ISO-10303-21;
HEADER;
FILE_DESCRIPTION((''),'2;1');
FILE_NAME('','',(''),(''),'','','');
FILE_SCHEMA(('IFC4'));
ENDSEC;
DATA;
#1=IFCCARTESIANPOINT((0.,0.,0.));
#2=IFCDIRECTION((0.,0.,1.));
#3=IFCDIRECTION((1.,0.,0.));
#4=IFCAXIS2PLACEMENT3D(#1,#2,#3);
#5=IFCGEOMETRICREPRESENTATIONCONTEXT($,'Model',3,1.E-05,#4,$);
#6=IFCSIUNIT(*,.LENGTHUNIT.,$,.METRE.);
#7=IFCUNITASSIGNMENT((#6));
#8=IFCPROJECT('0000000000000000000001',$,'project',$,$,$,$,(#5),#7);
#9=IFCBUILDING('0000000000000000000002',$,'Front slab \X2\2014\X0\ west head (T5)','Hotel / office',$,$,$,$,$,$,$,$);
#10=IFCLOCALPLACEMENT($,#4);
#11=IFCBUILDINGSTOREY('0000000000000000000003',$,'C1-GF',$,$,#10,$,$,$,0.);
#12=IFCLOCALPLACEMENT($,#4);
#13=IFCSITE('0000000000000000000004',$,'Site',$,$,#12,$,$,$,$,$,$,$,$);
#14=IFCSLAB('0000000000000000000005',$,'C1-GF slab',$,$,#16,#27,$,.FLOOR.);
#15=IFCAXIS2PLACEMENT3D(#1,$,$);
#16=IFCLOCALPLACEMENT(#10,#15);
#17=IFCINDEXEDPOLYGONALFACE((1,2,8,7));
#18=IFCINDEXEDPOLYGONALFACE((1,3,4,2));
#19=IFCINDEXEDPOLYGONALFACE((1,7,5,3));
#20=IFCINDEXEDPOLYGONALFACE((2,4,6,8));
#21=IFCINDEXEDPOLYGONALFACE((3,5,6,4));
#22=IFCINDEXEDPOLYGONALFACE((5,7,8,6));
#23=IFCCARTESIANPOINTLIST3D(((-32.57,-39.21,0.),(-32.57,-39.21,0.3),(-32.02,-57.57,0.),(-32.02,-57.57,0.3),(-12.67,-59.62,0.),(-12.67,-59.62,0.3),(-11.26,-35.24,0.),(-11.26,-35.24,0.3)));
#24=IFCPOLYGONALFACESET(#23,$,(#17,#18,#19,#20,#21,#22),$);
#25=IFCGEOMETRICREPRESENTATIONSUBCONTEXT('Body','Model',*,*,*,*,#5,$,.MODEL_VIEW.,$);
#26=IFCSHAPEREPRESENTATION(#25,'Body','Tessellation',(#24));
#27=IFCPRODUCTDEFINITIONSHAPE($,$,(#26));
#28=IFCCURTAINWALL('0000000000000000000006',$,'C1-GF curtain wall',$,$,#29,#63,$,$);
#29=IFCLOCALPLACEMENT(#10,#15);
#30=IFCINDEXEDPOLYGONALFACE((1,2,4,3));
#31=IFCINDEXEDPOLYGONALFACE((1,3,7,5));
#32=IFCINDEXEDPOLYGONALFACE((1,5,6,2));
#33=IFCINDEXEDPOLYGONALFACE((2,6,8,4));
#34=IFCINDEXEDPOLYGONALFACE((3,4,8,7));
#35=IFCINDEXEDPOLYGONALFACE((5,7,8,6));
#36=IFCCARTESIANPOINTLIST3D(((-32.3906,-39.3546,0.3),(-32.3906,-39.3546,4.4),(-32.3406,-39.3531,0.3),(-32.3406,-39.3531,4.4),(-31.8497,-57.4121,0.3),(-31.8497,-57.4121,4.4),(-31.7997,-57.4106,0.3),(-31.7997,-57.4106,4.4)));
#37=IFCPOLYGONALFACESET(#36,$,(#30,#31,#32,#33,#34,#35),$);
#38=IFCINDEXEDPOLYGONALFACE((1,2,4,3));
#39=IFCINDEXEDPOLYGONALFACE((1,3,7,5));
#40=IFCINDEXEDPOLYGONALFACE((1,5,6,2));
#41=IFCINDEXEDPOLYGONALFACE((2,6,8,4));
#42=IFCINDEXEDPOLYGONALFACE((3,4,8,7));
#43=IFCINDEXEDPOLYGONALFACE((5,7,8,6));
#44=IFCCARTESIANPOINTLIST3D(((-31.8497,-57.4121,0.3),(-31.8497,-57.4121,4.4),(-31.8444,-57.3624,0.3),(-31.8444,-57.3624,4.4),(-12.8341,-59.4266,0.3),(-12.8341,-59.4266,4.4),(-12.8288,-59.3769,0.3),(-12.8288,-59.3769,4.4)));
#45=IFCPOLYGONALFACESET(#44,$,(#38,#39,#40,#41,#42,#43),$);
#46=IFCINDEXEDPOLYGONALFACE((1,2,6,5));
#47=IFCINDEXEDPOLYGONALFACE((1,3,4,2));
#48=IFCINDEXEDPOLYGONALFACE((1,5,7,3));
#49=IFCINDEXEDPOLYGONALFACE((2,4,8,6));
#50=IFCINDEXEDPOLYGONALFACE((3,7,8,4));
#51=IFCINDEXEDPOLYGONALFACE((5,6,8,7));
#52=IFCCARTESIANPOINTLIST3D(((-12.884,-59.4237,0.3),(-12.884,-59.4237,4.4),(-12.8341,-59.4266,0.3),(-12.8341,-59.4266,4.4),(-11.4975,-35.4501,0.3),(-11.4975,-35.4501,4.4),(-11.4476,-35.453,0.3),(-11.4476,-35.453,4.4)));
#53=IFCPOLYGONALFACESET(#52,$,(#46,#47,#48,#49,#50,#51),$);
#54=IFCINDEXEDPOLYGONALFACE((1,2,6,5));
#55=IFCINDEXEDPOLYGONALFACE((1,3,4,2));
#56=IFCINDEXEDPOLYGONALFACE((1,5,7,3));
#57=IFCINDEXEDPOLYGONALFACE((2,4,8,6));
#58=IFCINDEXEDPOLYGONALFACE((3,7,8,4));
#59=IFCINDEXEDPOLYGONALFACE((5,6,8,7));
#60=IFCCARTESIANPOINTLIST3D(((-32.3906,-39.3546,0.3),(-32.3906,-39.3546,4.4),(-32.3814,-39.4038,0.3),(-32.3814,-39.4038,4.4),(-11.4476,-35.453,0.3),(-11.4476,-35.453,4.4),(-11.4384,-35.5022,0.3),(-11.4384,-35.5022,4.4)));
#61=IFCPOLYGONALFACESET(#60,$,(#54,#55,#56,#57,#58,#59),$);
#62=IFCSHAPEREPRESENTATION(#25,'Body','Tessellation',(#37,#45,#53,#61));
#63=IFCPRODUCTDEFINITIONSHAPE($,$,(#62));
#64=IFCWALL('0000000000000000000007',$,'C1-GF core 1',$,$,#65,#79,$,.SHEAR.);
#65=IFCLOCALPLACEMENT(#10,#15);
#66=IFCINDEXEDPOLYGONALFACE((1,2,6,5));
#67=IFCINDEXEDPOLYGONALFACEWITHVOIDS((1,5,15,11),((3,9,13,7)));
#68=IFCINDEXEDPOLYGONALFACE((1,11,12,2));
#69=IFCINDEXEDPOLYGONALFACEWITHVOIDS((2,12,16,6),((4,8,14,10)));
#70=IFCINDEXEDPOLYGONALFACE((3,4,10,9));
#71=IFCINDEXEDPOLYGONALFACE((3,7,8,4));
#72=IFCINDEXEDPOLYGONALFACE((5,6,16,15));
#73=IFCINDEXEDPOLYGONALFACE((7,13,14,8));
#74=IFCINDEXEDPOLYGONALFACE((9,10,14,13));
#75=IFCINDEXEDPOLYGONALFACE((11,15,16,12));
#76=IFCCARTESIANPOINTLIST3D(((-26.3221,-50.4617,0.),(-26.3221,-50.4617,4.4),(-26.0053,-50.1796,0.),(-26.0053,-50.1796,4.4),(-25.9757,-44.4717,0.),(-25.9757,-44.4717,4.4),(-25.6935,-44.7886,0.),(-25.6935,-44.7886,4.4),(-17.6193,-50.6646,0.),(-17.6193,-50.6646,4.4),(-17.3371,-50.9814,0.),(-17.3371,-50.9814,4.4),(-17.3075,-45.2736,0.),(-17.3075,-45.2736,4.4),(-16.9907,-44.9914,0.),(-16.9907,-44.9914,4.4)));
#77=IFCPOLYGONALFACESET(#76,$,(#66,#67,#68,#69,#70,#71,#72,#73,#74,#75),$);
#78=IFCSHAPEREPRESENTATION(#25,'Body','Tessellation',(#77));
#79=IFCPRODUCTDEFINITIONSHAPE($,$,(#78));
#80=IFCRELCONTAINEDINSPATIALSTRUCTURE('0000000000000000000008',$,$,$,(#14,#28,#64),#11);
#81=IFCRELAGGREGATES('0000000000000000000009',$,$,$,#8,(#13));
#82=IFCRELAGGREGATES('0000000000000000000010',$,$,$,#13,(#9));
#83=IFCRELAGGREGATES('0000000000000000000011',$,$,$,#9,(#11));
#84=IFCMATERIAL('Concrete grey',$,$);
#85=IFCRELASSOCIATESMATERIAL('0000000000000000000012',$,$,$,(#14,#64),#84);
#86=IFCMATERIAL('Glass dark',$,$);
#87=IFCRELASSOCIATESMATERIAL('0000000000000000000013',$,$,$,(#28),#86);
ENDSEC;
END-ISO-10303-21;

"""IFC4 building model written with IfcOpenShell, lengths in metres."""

from ifc_helpers import new_model, si_unit, frame, origin_with_axes, place, context, subcontext, project, spatial, polyline, outline, extrude, material, element, save


model = new_model("IFC4")

# Units and contexts
model_context = context("Model", 3, precision=1e-05, world=origin_with_axes())
body_context = subcontext(model_context, "Body", "Model", "MODEL_VIEW")
ifc_project = project(units=[si_unit("LENGTHUNIT", "METRE")], contexts=[model_context])

# Site, building, storey
site_placement = place(None, origin_with_axes())
site = spatial("IfcSite", under=ifc_project, at=site_placement, Name="Site")
building = spatial("IfcBuilding", under=site, Name="Front slab — west head (T5)", Description="Hotel / office")
storey_placement = place(None, origin_with_axes())
storey = spatial("IfcBuildingStorey", under=building, at=storey_placement, Name="C1-GF", Elevation=0.0)

# Slab
ifc_material_1 = material(Name="Concrete grey")
slab_placement = place(storey_placement, origin_with_axes())
element("IfcSlab", 1, at=slab_placement, inside=storey, material=ifc_material_1, Name="C1-GF slab", PredefinedType="FLOOR", context=body_context, shape_type="SweptSolid", body=[
    extrude(outline(polyline([(-32.57, -39.21), (-32.02, -57.57), (-12.67, -59.62), (-11.26, -35.24), (-32.57, -39.21)])), origin_with_axes(), (0.0, 0.0, 1.0), 0.3),
])

# Curtain wall
ifc_material_2 = material(Name="Glass dark")
curtain_wall_placement = place(storey_placement, origin_with_axes())
element("IfcCurtainWall", 2, at=curtain_wall_placement, inside=storey, material=ifc_material_2, Name="C1-GF curtain wall", context=body_context, shape_type="SweptSolid", body=[
    extrude(outline(polyline([(-32.3906, -39.3546), (-31.8497, -57.4121), (-31.7997, -57.4106), (-32.3406, -39.3531), (-32.3906, -39.3546)])), frame((0.0, 0.0, 0.3), z_axis=(0.0, 0.0, 1.0), x_axis=(1.0, 0.0, 0.0)), (0.0, 0.0, 1.0), 4.1),
    extrude(outline(polyline([(-31.8497, -57.4121), (-12.8341, -59.4266), (-12.8288, -59.3769), (-31.8444, -57.3624), (-31.8497, -57.4121)])), frame((0.0, 0.0, 0.3), z_axis=(0.0, 0.0, 1.0), x_axis=(1.0, 0.0, 0.0)), (0.0, 0.0, 1.0), 4.1),
    extrude(outline(polyline([(-12.8341, -59.4266), (-11.4476, -35.453), (-11.4975, -35.4501), (-12.884, -59.4237), (-12.8341, -59.4266)])), frame((0.0, 0.0, 0.3), z_axis=(0.0, 0.0, 1.0), x_axis=(1.0, 0.0, 0.0)), (0.0, 0.0, 1.0), 4.1),
    extrude(outline(polyline([(-11.4476, -35.453), (-32.3906, -39.3546), (-32.3814, -39.4038), (-11.4384, -35.5022), (-11.4476, -35.453)])), frame((0.0, 0.0, 0.3), z_axis=(0.0, 0.0, 1.0), x_axis=(1.0, 0.0, 0.0)), (0.0, 0.0, 1.0), 4.1),
])

# Wall
wall_placement = place(storey_placement, origin_with_axes())
element("IfcWall", 3, at=wall_placement, inside=storey, material=ifc_material_1, Name="C1-GF core 1", PredefinedType="SHEAR", context=body_context, shape_type="SweptSolid", body=[
    extrude(outline(polyline([(-17.3371, -50.9814), (-16.9907, -44.9914), (-25.9757, -44.4717), (-26.3221, -50.4617), (-17.3371, -50.9814)]), holes=[polyline([(-17.6193, -50.6646), (-17.3075, -45.2736), (-25.6935, -44.7886), (-26.0053, -50.1796), (-17.6193, -50.6646)])]), origin_with_axes(), (0.0, 0.0, 1.0), 4.4),
])

save(model, "model.ifc")
